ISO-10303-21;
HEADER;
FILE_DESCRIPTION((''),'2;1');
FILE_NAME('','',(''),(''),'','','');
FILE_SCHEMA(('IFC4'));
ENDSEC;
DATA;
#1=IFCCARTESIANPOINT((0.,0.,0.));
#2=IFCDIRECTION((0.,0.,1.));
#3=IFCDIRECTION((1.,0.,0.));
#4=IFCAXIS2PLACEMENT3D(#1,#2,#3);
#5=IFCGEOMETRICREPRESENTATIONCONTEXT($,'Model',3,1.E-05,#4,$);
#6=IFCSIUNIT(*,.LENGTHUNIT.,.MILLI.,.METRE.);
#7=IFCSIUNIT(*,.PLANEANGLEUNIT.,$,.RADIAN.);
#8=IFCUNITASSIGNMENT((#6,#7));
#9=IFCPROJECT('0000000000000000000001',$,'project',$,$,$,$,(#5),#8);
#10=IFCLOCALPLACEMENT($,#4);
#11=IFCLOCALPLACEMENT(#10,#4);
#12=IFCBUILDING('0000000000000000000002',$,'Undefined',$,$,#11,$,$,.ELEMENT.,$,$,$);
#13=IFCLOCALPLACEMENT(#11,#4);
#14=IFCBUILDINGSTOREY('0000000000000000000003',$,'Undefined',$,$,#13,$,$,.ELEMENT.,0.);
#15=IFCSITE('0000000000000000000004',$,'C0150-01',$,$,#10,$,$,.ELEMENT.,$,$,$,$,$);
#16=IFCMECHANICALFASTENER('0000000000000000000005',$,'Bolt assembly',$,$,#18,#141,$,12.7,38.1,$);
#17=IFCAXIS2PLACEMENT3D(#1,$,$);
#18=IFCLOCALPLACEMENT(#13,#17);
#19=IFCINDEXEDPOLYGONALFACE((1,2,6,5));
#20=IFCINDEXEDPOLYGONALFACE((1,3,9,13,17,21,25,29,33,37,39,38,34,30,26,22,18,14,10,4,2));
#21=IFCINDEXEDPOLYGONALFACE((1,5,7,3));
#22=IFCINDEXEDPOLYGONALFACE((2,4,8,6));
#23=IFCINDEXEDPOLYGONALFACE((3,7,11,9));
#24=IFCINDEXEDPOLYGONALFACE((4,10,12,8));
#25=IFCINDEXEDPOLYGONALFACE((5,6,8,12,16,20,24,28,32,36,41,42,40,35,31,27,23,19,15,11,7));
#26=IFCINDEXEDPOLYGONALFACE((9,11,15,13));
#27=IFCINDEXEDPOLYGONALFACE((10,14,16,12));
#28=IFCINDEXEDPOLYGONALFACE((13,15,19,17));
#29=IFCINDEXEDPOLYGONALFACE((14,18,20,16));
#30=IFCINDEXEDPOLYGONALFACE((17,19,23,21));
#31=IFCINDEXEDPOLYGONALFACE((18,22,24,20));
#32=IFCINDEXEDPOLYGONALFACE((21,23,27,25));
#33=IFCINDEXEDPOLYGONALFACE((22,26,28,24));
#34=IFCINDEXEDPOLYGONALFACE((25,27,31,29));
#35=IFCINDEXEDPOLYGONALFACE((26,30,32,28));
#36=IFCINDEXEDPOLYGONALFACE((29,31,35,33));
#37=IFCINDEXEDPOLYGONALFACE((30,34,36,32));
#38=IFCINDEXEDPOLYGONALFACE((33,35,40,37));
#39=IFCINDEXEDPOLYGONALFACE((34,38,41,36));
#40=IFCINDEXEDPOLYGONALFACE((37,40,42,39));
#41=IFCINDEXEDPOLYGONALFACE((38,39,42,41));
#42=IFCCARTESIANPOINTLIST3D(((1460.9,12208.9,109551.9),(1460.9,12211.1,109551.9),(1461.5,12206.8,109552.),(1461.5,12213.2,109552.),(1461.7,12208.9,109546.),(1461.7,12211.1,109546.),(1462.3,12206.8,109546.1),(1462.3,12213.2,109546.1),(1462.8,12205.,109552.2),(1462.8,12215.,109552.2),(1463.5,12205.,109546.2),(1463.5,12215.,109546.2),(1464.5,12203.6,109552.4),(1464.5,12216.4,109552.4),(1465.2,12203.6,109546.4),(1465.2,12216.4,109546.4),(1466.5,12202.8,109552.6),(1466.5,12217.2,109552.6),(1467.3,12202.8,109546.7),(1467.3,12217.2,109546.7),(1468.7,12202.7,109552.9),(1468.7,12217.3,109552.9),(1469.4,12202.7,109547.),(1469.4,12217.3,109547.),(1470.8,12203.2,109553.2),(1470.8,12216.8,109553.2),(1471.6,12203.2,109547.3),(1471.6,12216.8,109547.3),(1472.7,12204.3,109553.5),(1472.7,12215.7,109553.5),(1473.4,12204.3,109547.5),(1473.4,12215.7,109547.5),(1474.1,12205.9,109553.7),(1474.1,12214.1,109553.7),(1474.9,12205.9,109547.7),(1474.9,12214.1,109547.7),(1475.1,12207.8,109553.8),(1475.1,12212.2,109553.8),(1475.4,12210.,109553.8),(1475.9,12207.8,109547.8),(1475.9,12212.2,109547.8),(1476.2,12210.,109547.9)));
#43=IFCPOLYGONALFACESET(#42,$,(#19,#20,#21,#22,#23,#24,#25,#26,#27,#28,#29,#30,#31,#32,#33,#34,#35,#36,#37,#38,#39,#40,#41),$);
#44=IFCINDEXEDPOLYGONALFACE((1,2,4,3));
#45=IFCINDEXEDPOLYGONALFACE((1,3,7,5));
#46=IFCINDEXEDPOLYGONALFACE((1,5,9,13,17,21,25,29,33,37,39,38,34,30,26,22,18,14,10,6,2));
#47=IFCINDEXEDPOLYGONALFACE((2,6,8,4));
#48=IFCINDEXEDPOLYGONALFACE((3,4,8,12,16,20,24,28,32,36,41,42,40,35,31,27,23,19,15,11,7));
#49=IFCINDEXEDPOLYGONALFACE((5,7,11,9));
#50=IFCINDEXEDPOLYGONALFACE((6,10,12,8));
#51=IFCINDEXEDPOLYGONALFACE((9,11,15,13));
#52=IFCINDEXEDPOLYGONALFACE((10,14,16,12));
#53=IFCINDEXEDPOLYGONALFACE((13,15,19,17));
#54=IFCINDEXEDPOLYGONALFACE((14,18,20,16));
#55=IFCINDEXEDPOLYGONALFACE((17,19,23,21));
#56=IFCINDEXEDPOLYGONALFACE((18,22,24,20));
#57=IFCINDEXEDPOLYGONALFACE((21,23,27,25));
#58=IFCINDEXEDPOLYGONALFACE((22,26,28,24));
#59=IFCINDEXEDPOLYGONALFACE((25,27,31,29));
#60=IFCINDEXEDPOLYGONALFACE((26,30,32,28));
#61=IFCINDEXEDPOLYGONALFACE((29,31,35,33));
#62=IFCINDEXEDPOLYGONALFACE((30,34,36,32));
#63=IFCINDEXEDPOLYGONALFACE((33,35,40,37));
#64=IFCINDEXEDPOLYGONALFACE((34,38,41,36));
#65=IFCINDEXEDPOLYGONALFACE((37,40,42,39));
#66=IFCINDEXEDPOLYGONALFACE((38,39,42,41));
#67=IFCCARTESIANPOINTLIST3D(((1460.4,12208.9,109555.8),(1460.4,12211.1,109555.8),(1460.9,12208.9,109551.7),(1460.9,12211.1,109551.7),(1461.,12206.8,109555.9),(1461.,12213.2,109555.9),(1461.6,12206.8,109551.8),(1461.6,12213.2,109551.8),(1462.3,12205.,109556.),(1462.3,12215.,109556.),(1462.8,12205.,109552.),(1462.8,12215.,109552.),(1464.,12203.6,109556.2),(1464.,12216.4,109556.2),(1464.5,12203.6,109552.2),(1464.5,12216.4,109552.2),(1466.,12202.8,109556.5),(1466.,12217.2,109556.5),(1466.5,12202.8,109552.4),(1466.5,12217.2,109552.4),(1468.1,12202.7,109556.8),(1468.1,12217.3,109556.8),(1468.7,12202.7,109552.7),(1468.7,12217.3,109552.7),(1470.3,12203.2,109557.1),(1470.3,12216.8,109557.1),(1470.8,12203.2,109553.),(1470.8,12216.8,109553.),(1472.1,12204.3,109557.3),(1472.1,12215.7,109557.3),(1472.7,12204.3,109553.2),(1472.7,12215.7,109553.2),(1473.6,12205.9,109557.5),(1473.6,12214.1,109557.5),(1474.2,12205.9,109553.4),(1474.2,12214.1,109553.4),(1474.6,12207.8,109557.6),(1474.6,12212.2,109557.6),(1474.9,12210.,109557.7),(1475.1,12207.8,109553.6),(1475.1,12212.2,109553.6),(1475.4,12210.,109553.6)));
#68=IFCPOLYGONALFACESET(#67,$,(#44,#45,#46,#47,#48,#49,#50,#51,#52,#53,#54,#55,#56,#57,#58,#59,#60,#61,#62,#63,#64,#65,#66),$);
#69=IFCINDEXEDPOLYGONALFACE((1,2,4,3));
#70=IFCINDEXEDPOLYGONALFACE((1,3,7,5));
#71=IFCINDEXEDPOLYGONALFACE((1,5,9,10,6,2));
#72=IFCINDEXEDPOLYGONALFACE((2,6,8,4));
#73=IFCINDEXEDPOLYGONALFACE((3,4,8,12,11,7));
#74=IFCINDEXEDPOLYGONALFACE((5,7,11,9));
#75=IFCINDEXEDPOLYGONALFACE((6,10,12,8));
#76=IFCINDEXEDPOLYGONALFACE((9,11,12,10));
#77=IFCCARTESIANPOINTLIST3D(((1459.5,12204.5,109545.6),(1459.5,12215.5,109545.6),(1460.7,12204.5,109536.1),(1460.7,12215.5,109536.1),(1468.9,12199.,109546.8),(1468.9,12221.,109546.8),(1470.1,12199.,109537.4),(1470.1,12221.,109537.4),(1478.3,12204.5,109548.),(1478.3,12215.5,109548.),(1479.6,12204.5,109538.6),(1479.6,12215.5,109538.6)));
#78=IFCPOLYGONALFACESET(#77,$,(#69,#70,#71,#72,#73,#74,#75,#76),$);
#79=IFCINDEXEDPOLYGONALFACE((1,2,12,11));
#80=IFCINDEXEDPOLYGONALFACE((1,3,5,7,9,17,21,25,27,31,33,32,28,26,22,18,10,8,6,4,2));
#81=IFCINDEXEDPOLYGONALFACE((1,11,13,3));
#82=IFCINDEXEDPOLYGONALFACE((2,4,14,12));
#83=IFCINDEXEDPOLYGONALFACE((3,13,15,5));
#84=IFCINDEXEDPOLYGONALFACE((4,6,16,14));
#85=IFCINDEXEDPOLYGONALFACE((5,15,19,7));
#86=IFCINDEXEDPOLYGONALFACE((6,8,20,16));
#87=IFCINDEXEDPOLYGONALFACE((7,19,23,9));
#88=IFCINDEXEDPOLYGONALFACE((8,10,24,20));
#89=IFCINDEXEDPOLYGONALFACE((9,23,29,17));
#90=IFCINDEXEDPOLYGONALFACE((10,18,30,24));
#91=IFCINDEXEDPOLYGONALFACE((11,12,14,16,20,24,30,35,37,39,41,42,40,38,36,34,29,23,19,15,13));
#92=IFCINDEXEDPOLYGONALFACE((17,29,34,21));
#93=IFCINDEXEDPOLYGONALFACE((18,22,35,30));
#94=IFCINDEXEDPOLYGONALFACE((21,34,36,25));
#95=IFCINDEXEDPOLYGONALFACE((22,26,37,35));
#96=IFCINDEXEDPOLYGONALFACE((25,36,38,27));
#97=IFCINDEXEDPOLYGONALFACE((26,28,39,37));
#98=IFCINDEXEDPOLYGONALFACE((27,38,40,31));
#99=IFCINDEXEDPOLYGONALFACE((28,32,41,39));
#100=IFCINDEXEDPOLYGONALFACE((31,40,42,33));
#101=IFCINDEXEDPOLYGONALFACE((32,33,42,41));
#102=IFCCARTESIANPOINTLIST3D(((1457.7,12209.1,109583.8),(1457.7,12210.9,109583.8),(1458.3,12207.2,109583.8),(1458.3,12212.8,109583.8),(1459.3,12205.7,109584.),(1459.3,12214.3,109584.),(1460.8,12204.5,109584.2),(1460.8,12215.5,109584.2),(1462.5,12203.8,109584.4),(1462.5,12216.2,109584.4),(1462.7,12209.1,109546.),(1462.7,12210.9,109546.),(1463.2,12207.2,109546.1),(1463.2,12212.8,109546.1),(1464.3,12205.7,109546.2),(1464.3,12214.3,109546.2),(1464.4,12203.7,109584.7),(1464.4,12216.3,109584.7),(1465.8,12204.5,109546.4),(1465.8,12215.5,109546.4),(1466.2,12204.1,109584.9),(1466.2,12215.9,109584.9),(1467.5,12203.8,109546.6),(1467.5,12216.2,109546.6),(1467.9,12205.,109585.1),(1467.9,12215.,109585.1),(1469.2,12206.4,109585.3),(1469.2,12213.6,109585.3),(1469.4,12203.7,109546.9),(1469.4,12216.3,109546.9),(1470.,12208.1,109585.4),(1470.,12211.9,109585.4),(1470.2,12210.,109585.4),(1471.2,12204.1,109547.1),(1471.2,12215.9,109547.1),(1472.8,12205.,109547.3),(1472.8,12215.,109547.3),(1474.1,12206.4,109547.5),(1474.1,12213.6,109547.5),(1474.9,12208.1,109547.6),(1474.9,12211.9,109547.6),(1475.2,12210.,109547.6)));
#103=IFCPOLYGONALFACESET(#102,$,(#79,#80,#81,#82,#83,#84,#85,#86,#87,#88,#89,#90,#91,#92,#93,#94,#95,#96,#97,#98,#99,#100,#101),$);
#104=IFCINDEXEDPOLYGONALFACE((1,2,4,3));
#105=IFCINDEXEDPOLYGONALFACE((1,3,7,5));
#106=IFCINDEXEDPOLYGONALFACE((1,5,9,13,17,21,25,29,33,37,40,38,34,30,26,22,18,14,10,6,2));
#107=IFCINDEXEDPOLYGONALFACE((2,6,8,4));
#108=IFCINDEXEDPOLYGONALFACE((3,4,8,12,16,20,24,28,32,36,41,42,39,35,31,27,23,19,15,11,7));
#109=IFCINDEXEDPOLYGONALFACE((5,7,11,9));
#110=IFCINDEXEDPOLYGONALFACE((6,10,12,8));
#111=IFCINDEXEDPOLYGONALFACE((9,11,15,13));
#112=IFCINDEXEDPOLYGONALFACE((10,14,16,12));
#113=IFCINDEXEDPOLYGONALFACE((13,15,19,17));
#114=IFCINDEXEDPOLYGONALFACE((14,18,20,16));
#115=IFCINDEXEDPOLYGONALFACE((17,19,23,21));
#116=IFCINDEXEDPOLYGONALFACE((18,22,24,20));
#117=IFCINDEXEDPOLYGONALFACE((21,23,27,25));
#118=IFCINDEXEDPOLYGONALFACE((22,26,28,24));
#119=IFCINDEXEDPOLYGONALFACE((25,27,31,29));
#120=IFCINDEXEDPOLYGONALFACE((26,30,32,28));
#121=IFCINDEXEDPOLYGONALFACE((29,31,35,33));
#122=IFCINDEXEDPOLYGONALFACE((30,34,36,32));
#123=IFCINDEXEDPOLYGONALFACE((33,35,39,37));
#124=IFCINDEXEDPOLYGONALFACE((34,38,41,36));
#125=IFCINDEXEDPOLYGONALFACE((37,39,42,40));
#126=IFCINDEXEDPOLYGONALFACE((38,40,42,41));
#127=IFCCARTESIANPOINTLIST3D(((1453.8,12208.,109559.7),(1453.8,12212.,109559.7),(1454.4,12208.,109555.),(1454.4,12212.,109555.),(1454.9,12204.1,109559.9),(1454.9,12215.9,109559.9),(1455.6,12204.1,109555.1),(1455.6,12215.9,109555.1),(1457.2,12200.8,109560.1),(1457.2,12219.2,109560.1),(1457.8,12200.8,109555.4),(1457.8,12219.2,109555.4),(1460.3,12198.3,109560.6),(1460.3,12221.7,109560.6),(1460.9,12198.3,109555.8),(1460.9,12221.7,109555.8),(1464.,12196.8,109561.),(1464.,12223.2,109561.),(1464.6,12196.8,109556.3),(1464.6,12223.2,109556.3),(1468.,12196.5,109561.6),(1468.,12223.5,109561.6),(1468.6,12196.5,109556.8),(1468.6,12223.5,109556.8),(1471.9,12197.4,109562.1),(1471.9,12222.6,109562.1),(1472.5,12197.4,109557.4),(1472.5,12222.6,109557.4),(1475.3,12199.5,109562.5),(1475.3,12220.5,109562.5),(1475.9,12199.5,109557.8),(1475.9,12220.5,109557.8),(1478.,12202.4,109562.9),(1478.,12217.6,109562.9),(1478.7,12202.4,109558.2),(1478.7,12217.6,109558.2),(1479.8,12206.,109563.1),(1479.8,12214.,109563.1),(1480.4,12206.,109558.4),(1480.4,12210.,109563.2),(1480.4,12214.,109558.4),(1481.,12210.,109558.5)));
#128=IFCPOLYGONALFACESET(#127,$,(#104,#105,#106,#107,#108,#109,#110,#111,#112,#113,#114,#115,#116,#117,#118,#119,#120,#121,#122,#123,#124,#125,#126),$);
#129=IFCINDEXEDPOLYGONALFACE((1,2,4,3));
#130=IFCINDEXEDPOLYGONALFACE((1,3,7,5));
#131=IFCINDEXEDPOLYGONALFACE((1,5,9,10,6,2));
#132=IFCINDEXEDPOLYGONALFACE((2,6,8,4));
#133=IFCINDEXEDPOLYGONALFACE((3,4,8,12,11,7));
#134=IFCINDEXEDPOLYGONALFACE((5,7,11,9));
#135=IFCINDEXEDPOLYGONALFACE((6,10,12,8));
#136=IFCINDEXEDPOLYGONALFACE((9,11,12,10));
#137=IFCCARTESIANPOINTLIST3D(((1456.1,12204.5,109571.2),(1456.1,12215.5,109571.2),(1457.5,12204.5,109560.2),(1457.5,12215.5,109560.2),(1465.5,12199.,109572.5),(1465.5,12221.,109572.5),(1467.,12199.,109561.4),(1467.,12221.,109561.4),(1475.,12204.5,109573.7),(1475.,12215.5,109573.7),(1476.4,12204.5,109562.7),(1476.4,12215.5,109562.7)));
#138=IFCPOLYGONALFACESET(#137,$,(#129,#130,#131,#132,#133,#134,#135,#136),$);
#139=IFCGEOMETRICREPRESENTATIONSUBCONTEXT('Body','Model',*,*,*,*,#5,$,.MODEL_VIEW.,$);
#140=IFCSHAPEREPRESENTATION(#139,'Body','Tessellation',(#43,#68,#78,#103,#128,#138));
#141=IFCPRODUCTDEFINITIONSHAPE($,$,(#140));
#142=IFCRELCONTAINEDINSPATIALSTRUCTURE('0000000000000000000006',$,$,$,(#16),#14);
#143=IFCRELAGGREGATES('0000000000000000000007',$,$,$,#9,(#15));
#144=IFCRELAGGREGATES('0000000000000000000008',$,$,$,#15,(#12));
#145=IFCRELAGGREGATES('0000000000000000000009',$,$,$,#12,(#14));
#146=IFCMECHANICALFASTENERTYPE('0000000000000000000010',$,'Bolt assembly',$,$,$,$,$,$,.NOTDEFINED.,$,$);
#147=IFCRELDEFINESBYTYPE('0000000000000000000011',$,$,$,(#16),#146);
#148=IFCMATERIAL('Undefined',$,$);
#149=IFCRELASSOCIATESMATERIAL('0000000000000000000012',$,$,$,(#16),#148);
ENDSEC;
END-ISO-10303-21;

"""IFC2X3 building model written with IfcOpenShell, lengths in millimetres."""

from ifc_helpers import new_model, si_unit, frame, origin_with_axes, origin_2d_with_axis, place, context, subcontext, project, spatial, polyline, circle, outline, extrude, source, transform, mapped, material, type_object, element, save


model = new_model("IFC2X3")

# Units and contexts
model_context = context("Model", 3, precision=1e-05, world=origin_with_axes())
body_context = subcontext(model_context, "Body", "Model", "MODEL_VIEW")
ifc_project = project(units=[si_unit("LENGTHUNIT", "METRE", prefix="MILLI"), si_unit("PLANEANGLEUNIT", "RADIAN")], contexts=[model_context])

# Site, building, storey
site_placement = place(None, origin_with_axes())
site = spatial("IfcSite", under=ifc_project, at=site_placement, Name="C0150-01", CompositionType="ELEMENT")
building_placement = place(site_placement, origin_with_axes())
building = spatial("IfcBuilding", under=site, at=building_placement, Name="Undefined", CompositionType="ELEMENT")
storey_placement = place(building_placement, origin_with_axes())
storey = spatial("IfcBuildingStorey", under=building, at=storey_placement, Name="Undefined", CompositionType="ELEMENT", Elevation=0.0)

# Mechanical fastener
ifc_material_1 = material(Name="Undefined")
mechanical_fastener_type = type_object("IfcMechanicalFastenerType", Name="Bolt assembly")
shared_shape_1 = source(origin_with_axes(), body_context, "Body", "SweptSolid", [
    extrude(circle(Radius=7.3, at=origin_2d_with_axis()), frame((0.0, -9.9, 0.0), z_axis=(0.0, 1.0, 0.0), x_axis=(1.0, 0.0, 0.0)), (0.0, 0.0, 1.0), 6.0),
    extrude(circle(Radius=7.3, at=origin_2d_with_axis()), frame((0.0, -4.1, 0.0), z_axis=(0.0, 1.0, 0.0), x_axis=(1.0, 0.0, 0.0)), (0.0, 0.0, 1.0), 4.1),
    extrude(outline(polyline([(9.5, -5.5), (9.5, 5.5), (0.0, 11.0), (-9.5, 5.5), (-9.5, -5.5), (0.0, -11.0), (9.5, -5.5)])), frame((0.0, -19.5, 0.0), z_axis=(0.0, 1.0, 0.0), x_axis=(1.0, 0.0, 0.0)), (0.0, 0.0, 1.0), 9.5),
    extrude(circle(Radius=6.3, at=origin_2d_with_axis()), frame((0.0, -10.0, 0.0), z_axis=(0.0, 1.0, 0.0), x_axis=(1.0, 0.0, 0.0)), (0.0, 0.0, 1.0), 38.1),
    extrude(circle(Radius=13.5, at=origin_2d_with_axis()), frame((0.0, 0.0, 0.0), z_axis=(0.0, 1.0, 0.0), x_axis=(1.0, 0.0, 0.0)), (0.0, 0.0, 1.0), 4.8),
    extrude(outline(polyline([(9.5, -5.5), (9.5, 5.5), (0.0, 11.0), (-9.5, 5.5), (-9.5, -5.5), (0.0, -11.0), (9.5, -5.5)])), frame((0.0, 4.8, 0.0), z_axis=(0.0, 1.0, 0.0), x_axis=(1.0, 0.0, 0.0)), (0.0, 0.0, 1.0), 11.1),
])
for number, where, z_axis, x_axis, name in (
    (1, (1467.6, 12210.0, 109556.7), (0.0, -1.0, 0.0), (0.991507, 0.0, 0.130054), "Bolt assembly"),
):
    element("IfcMechanicalFastener", number, at=place(storey_placement, frame(where, z_axis=z_axis, x_axis=x_axis)), inside=storey, type_object=mechanical_fastener_type, material=ifc_material_1, Name=name, NominalDiameter=12.7, NominalLength=38.1, context=body_context, shape_type="MappedRepresentation", body=[
        mapped(shared_shape_1, transform((0.0, 0.0, 0.0))),
    ])

save(model, "model.ifc")
